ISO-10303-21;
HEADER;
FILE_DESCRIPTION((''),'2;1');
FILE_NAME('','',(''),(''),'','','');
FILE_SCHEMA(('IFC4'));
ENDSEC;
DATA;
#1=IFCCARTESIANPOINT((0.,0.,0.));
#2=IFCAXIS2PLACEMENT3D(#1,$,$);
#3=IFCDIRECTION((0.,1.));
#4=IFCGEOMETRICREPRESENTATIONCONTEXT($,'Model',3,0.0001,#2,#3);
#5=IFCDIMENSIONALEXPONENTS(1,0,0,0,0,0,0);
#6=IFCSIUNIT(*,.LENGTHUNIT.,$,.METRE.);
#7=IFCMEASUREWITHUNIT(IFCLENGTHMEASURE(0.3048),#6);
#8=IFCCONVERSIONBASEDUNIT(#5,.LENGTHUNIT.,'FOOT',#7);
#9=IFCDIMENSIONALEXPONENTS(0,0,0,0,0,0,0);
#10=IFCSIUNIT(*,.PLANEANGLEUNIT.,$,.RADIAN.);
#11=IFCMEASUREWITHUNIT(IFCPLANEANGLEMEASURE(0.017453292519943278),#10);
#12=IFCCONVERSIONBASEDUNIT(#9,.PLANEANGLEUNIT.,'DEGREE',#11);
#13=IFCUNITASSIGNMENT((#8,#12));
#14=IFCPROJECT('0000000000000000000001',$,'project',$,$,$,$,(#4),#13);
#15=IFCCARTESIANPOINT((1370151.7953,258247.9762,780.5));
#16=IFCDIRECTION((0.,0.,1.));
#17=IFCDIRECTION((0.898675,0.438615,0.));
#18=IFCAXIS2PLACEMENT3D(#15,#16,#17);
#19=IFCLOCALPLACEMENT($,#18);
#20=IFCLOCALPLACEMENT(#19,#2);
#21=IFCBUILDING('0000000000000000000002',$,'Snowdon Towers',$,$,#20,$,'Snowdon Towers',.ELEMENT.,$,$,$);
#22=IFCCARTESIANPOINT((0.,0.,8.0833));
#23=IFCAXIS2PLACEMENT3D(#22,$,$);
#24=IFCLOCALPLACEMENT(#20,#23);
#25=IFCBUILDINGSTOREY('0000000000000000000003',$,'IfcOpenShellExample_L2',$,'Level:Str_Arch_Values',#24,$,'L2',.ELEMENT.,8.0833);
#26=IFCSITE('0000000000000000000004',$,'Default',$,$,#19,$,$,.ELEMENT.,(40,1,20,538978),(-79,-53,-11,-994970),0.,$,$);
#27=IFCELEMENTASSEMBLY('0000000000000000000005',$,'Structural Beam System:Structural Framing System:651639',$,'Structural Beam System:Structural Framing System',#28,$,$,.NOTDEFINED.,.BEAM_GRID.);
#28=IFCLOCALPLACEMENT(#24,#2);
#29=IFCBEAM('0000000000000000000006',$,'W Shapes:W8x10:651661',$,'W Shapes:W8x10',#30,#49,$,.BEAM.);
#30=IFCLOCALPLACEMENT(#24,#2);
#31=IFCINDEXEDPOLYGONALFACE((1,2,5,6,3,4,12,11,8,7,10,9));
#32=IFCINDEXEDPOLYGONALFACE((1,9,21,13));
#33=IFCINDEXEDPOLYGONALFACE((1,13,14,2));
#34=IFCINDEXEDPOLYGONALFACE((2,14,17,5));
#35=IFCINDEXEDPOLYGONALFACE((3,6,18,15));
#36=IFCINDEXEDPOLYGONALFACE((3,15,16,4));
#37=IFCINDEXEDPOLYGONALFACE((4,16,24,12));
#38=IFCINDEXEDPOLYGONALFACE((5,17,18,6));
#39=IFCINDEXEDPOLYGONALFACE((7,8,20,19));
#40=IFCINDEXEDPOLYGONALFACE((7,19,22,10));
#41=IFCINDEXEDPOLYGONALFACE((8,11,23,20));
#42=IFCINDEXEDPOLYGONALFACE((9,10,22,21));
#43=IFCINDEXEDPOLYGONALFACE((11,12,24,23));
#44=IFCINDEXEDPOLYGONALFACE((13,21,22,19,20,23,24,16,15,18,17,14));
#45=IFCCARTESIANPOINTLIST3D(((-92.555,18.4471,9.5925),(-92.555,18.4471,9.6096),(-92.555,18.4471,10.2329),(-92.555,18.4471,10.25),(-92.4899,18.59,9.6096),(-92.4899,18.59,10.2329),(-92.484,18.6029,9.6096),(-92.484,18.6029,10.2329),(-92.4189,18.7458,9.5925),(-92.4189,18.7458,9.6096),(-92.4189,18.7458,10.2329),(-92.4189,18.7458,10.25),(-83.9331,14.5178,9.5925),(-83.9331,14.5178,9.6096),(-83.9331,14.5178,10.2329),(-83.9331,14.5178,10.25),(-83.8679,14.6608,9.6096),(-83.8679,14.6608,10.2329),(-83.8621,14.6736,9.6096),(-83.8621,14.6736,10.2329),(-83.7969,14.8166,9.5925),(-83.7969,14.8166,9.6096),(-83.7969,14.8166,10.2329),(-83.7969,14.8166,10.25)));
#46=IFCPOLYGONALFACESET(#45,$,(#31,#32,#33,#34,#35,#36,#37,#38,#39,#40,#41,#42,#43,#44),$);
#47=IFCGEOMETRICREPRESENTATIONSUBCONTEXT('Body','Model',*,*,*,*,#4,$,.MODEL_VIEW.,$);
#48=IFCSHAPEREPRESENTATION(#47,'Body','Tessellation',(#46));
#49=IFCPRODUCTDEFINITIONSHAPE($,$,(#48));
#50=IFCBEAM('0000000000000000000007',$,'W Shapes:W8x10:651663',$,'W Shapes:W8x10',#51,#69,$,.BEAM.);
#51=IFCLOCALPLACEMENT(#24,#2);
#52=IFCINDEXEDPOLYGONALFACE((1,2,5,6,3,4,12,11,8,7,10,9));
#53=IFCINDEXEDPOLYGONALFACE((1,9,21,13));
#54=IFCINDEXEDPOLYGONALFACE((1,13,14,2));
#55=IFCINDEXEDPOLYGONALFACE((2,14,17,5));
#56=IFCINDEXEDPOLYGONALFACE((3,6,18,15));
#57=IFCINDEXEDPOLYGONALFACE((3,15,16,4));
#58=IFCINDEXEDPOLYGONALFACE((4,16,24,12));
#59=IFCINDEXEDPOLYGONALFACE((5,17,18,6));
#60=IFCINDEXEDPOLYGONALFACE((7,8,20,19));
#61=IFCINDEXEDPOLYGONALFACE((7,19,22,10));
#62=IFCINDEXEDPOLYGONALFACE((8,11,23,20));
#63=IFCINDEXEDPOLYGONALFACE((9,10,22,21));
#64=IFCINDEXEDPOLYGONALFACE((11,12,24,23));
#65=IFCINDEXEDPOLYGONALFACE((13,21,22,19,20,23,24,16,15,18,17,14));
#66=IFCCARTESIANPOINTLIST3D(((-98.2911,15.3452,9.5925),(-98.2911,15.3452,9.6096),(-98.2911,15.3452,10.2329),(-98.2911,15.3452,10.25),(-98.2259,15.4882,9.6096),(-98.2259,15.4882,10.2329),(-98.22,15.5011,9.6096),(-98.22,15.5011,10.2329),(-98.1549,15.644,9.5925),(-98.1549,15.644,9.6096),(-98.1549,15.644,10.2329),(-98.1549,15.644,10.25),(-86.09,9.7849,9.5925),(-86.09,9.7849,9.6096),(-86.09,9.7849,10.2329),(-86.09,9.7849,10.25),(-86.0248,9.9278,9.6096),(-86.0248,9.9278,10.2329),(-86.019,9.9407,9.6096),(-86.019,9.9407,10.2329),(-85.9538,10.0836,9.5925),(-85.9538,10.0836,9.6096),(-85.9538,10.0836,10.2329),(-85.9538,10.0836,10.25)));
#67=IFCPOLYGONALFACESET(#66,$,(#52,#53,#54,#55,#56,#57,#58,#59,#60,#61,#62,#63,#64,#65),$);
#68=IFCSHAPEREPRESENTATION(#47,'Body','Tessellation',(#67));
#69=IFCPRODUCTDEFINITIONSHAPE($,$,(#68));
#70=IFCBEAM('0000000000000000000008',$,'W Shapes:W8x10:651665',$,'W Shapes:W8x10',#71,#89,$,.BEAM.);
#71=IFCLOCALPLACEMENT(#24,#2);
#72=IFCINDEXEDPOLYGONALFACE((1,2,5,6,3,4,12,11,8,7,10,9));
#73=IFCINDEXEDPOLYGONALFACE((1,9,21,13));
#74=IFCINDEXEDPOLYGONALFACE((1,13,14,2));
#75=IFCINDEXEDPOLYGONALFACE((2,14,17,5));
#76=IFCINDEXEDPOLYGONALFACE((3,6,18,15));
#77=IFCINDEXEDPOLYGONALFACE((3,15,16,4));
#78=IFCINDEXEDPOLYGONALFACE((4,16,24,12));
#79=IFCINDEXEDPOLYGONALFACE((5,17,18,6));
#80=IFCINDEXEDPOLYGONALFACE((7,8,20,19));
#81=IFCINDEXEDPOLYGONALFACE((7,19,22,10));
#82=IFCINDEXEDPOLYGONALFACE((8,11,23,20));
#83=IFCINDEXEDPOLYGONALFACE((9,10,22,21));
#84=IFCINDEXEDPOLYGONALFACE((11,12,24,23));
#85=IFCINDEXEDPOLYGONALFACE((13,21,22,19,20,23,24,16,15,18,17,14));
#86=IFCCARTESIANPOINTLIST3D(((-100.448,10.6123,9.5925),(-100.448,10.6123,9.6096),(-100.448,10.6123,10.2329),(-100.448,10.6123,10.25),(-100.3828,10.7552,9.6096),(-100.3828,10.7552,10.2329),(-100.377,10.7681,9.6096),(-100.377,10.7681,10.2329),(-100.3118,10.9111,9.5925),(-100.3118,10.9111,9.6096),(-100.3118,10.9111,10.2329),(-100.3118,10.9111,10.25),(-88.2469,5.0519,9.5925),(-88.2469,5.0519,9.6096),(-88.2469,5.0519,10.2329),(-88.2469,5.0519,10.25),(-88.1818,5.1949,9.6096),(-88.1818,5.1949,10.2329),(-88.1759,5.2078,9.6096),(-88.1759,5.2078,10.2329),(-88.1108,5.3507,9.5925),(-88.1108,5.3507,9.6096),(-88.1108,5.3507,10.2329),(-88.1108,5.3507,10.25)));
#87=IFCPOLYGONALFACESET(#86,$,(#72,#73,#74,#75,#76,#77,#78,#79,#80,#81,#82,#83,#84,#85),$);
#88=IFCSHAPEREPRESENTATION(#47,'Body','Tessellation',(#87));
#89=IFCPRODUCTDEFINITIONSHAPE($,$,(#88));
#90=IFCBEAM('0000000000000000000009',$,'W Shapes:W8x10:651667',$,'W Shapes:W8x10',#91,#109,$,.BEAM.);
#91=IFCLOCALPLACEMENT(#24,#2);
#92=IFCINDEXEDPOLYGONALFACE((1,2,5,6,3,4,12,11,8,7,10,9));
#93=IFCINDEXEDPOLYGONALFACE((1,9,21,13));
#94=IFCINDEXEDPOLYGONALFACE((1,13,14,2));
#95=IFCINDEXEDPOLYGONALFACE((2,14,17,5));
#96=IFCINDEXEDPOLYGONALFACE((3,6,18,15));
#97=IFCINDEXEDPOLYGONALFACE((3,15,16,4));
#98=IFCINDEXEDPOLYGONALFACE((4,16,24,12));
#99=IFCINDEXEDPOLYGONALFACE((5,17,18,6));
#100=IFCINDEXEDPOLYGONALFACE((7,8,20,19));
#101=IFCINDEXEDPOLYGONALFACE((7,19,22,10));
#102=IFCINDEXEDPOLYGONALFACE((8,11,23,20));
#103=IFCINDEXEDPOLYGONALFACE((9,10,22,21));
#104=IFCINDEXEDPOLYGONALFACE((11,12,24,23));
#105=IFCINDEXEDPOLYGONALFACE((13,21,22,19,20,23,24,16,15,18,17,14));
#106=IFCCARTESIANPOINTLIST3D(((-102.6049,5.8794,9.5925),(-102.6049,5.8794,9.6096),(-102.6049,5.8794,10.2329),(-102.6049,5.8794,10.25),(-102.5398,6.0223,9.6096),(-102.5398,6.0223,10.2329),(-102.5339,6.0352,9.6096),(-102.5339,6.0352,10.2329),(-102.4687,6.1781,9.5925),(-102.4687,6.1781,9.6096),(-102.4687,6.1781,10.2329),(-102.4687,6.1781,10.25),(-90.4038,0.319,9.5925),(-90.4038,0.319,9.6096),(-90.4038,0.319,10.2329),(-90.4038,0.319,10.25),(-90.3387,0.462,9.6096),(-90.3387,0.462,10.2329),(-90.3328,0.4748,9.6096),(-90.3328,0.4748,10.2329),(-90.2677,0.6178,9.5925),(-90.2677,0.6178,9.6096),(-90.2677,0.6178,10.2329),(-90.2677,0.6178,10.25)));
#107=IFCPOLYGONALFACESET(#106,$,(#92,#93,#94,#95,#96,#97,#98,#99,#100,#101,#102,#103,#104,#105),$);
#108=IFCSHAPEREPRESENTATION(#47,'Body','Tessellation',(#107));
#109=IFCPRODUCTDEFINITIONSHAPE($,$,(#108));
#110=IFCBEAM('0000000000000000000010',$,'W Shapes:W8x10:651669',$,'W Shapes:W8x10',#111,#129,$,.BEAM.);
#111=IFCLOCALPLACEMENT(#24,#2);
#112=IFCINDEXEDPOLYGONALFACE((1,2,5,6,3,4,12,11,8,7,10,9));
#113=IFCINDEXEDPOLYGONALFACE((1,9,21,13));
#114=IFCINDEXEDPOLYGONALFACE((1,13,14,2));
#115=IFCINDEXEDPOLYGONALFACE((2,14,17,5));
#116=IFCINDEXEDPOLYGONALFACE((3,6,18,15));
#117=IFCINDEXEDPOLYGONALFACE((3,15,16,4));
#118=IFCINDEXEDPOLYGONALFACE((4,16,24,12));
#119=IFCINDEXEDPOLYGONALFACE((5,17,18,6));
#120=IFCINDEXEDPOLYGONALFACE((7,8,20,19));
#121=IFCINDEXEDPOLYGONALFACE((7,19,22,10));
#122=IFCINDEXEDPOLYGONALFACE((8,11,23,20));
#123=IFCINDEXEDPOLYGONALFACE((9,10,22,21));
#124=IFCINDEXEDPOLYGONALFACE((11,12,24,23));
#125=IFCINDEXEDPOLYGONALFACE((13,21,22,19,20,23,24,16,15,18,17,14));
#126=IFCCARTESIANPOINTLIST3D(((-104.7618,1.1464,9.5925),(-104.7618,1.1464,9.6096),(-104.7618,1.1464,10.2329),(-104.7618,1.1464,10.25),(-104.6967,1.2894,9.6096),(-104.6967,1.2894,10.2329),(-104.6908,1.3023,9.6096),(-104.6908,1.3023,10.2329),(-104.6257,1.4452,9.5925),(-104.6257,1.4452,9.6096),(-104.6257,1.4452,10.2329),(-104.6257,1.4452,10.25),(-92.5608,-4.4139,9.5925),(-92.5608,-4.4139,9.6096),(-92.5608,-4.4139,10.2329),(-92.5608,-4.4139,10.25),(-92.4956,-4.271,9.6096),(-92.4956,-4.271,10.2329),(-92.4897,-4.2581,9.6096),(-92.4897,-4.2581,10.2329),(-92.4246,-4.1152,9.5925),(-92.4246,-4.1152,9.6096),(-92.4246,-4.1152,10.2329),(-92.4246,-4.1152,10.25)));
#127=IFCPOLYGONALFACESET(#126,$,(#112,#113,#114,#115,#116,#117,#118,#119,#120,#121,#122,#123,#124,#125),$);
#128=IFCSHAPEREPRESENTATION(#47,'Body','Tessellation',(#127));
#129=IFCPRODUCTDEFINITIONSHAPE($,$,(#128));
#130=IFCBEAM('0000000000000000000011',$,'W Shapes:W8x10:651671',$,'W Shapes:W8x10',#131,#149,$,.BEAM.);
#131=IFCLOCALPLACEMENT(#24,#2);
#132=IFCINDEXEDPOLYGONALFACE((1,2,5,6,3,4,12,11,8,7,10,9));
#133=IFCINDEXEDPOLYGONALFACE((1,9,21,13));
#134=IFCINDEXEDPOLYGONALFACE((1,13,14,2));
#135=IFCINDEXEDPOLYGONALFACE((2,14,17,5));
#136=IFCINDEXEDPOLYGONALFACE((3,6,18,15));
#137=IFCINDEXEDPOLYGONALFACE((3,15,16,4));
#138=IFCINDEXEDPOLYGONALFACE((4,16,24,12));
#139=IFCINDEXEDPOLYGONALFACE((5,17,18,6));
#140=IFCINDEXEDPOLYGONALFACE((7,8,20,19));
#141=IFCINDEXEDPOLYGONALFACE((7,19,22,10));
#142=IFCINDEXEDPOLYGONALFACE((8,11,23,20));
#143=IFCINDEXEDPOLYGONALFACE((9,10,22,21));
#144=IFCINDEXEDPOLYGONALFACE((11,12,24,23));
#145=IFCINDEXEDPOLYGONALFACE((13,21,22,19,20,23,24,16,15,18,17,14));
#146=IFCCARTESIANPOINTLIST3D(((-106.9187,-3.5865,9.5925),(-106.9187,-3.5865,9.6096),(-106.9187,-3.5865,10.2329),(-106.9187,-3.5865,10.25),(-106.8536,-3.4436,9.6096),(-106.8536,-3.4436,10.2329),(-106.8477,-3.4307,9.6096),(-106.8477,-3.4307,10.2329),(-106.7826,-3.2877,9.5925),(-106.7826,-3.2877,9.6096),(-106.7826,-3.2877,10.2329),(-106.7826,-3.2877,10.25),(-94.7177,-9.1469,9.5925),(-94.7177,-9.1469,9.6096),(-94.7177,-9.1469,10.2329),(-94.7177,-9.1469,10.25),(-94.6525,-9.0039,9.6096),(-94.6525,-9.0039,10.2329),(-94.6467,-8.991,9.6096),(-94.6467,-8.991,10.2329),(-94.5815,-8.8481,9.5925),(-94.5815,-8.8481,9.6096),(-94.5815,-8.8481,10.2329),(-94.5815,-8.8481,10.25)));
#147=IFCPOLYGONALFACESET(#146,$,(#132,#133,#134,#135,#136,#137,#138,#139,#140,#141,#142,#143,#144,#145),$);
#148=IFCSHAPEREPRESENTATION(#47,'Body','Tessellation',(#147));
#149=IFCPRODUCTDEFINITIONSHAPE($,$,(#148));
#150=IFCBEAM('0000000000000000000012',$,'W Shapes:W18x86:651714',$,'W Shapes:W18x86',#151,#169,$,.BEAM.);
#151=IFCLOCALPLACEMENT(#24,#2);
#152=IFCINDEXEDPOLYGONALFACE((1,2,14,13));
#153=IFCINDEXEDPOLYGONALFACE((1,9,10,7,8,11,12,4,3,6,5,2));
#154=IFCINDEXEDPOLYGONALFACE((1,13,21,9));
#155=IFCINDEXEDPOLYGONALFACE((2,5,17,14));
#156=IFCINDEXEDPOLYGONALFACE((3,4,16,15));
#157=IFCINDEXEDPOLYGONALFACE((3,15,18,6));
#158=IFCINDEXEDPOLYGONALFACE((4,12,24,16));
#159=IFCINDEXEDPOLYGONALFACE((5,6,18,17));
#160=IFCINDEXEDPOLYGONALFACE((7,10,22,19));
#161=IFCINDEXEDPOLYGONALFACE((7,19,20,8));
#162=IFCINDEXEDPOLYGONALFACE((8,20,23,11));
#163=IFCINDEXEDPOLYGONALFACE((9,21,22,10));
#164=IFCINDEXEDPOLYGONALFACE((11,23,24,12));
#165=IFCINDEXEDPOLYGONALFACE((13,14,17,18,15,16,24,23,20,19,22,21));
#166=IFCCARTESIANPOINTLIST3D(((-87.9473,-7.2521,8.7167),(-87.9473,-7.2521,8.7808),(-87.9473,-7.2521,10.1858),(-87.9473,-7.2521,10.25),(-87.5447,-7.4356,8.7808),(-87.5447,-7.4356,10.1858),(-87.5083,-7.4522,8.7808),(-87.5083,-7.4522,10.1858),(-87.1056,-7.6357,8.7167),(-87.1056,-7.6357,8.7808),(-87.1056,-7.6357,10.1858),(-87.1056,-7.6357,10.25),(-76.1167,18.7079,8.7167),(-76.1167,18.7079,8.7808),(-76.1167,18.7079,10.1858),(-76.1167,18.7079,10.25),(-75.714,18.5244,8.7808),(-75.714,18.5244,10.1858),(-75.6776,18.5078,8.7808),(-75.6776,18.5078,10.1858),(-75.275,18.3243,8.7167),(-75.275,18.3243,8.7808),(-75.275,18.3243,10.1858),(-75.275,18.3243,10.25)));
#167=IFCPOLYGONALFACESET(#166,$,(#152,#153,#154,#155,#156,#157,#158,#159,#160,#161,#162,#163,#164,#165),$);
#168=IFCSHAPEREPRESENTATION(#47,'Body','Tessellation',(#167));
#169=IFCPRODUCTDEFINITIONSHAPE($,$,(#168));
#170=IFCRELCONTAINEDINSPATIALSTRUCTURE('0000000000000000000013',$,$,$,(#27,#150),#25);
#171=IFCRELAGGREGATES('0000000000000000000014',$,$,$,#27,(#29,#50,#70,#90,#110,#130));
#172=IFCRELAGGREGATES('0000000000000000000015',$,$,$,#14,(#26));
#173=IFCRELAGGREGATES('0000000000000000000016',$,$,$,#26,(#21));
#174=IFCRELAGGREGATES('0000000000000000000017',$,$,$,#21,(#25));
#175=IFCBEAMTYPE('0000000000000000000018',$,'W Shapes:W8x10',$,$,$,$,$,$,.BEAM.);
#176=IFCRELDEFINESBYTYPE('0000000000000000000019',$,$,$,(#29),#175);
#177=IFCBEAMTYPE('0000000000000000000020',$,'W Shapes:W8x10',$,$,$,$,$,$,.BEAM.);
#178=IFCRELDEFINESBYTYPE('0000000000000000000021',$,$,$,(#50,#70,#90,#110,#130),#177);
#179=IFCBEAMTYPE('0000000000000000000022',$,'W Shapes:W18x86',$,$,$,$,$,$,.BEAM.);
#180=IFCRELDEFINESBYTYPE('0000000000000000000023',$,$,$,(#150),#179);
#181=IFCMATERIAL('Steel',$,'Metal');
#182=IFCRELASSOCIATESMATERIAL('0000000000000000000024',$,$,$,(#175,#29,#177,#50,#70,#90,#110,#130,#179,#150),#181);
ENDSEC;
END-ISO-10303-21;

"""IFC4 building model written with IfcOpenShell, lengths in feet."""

from ifc_helpers import new_model, entity, si_unit, converted_unit, direction, frame, origin, place, context, subcontext, project, spatial, indexed_curve, outline, extrude, source, transform, mapped, material, type_object, type_shapes, element, aggregate, save


model = new_model("IFC4")

# Units and contexts
model_context = context("Model", 3, precision=0.0001, world=origin(), true_north=direction((0.0, 1.0)))
body_context = subcontext(model_context, "Body", "Model", "MODEL_VIEW")
ifc_project = project(units=[converted_unit("LENGTHUNIT", "FOOT", entity("IfcLengthMeasure", 0.3048), si_unit("LENGTHUNIT", "METRE"), dimensions=[1, 0, 0, 0, 0, 0, 0]), converted_unit("PLANEANGLEUNIT", "DEGREE", entity("IfcPlaneAngleMeasure", 0.017453292519943278), si_unit("PLANEANGLEUNIT", "RADIAN"), dimensions=[0, 0, 0, 0, 0, 0, 0])], contexts=[model_context])

# Site, building, storey
site_placement = place(None, frame((1370151.7953, 258247.9762, 780.5), z_axis=(0.0, 0.0, 1.0), x_axis=(0.898675, 0.438615, 0.0)))
site = spatial("IfcSite", under=ifc_project, at=site_placement, Name="Default", CompositionType="ELEMENT", RefLatitude=(40, 1, 20, 538978), RefLongitude=(-79, -53, -11, -994970), RefElevation=0.0)
building_placement = place(site_placement, origin())
building = spatial("IfcBuilding", under=site, at=building_placement, Name="Snowdon Towers", LongName="Snowdon Towers", CompositionType="ELEMENT")
storey_placement = place(building_placement, frame((0.0, 0.0, 8.0833)))
storey = spatial("IfcBuildingStorey", under=building, at=storey_placement, Name="IfcOpenShellExample_L2", ObjectType="Level:Str_Arch_Values", LongName="L2", CompositionType="ELEMENT", Elevation=8.0833)

# Shared definitions
ifc_material = material(Name="Steel", Category="Metal")

# Element assembly, beams
assembly_1_placement = place(storey_placement, origin())
assembly_1 = element("IfcElementAssembly", 1, at=assembly_1_placement, inside=storey, Name="Structural Beam System:Structural Framing System:651639", ObjectType="Structural Beam System:Structural Framing System", AssemblyPlace="NOTDEFINED", PredefinedType="BEAM_GRID")
beam_type_1 = type_object("IfcBeamType", Name="W Shapes:W8x10", PredefinedType="BEAM", material=ifc_material)
shared_shape_1 = source(origin(), body_context, "Body", "SweptSolid", [
    extrude(outline(indexed_curve([(-0.1642, -0.3117), (-0.1642, -0.3288), (0.1642, -0.3288), (0.1642, -0.3117), (0.0071, -0.3117), (0.0071, 0.3117), (0.1642, 0.3117), (0.1642, 0.3287), (-0.1642, 0.3287), (-0.1642, 0.3117), (-0.0071, 0.3117), (-0.0071, -0.3117), (-0.1642, -0.3117)], self_intersect=False)), frame((-4.231, 0.0, 0.0), z_axis=(-1.0, 0.0, 0.0), x_axis=(0.0, -1.0, 0.0)), (0.0, 0.0, -1.0), 9.4751),
])
type_shapes(beam_type_1, [shared_shape_1])
beam_1_placement = place(assembly_1_placement, frame((-88.6369, 16.8419, 9.9213), z_axis=(0.0, 0.0, 1.0), x_axis=(0.909961, -0.414693, 0.0)))
beam_1 = element("IfcBeam", 2, at=beam_1_placement, type_object=beam_type_1, material=ifc_material, Name="W Shapes:W8x10:651661", ObjectType="W Shapes:W8x10", PredefinedType="BEAM", context=body_context, shape_type="MappedRepresentation", body=[
    mapped(shared_shape_1, transform((0.0, 0.0, 0.0), scale=1.0)),
])
beam_type_2 = type_object("IfcBeamType", Name="W Shapes:W8x10", PredefinedType="BEAM", material=ifc_material)
shared_shape_2 = source(origin(), body_context, "Body", "SweptSolid", [
    extrude(outline(indexed_curve([(-0.1642, -0.3117), (-0.1642, -0.3288), (0.1642, -0.3288), (0.1642, -0.3117), (0.0071, -0.3117), (0.0071, 0.3117), (0.1642, 0.3117), (0.1642, 0.3287), (-0.1642, 0.3287), (-0.1642, 0.3117), (-0.0071, 0.3117), (-0.0071, -0.3117), (-0.1642, -0.3117)], self_intersect=False)), frame((-6.7042, 0.0, 0.0), z_axis=(-1.0, 0.0, 0.0), x_axis=(0.0, -1.0, 0.0)), (0.0, 0.0, -1.0), 13.4083),
])
type_shapes(beam_type_2, [shared_shape_2])
beam_2_placement = place(assembly_1_placement, frame((-92.1224, 12.7144, 9.9213), z_axis=(0.0, 0.0, 1.0), x_axis=(0.909961, -0.414693, 0.0)))
beam_2 = element("IfcBeam", 3, at=beam_2_placement, type_object=beam_type_2, material=ifc_material, Name="W Shapes:W8x10:651663", ObjectType="W Shapes:W8x10", PredefinedType="BEAM", context=body_context, shape_type="MappedRepresentation", body=[
    mapped(shared_shape_2, transform((0.0, 0.0, 0.0), scale=1.0)),
])
beam_3_placement = place(assembly_1_placement, frame((-94.2794, 7.9815, 9.9213), z_axis=(0.0, 0.0, 1.0), x_axis=(0.909961, -0.414693, 0.0)))
beam_3 = element("IfcBeam", 4, at=beam_3_placement, type_object=beam_type_2, material=ifc_material, Name="W Shapes:W8x10:651665", ObjectType="W Shapes:W8x10", PredefinedType="BEAM", context=body_context, shape_type="MappedRepresentation", body=[
    mapped(shared_shape_2, transform((0.0, 0.0, 0.0), scale=1.0)),
])
beam_4_placement = place(assembly_1_placement, frame((-96.4363, 3.2486, 9.9213), z_axis=(0.0, 0.0, 1.0), x_axis=(0.909961, -0.414693, 0.0)))
beam_4 = element("IfcBeam", 5, at=beam_4_placement, type_object=beam_type_2, material=ifc_material, Name="W Shapes:W8x10:651667", ObjectType="W Shapes:W8x10", PredefinedType="BEAM", context=body_context, shape_type="MappedRepresentation", body=[
    mapped(shared_shape_2, transform((0.0, 0.0, 0.0), scale=1.0)),
])
beam_5_placement = place(assembly_1_placement, frame((-98.5932, -1.4844, 9.9213), z_axis=(0.0, 0.0, 1.0), x_axis=(0.909961, -0.414693, 0.0)))
beam_5 = element("IfcBeam", 6, at=beam_5_placement, type_object=beam_type_2, material=ifc_material, Name="W Shapes:W8x10:651669", ObjectType="W Shapes:W8x10", PredefinedType="BEAM", context=body_context, shape_type="MappedRepresentation", body=[
    mapped(shared_shape_2, transform((0.0, 0.0, 0.0), scale=1.0)),
])
beam_6_placement = place(assembly_1_placement, frame((-100.7501, -6.2173, 9.9213), z_axis=(0.0, 0.0, 1.0), x_axis=(0.909961, -0.414693, 0.0)))
beam_6 = element("IfcBeam", 7, at=beam_6_placement, type_object=beam_type_2, material=ifc_material, Name="W Shapes:W8x10:651671", ObjectType="W Shapes:W8x10", PredefinedType="BEAM", context=body_context, shape_type="MappedRepresentation", body=[
    mapped(shared_shape_2, transform((0.0, 0.0, 0.0), scale=1.0)),
])
aggregate(assembly_1, [beam_1, beam_2, beam_3, beam_4, beam_5, beam_6])

# Beam
beam_type_3 = type_object("IfcBeamType", Name="W Shapes:W18x86", PredefinedType="BEAM", material=ifc_material)
shared_shape_3 = source(origin(), body_context, "Body", "SweptSolid", [
    extrude(outline(indexed_curve([(-0.4625, -0.7025), (-0.4625, -0.7667), (0.4625, -0.7667), (0.4625, -0.7025), (0.02, -0.7025), (0.02, 0.7025), (0.4625, 0.7025), (0.4625, 0.7667), (-0.4625, 0.7667), (-0.4625, 0.7025), (-0.02, 0.7025), (-0.02, -0.7025), (-0.4625, -0.7025)], self_intersect=False)), frame((-14.3926, 0.0, 0.0), z_axis=(-1.0, 0.0, 0.0), x_axis=(0.0, -1.0, 0.0)), (0.0, 0.0, -1.0), 28.5287),
])
type_shapes(beam_type_3, [shared_shape_3])
beam_7_placement = place(storey_placement, frame((-81.558, 5.6528, 9.4833), z_axis=(0.0, 0.0, 1.0), x_axis=(0.414693, 0.909961, 0.0)))
element("IfcBeam", 8, at=beam_7_placement, inside=storey, type_object=beam_type_3, material=ifc_material, Name="W Shapes:W18x86:651714", ObjectType="W Shapes:W18x86", PredefinedType="BEAM", context=body_context, shape_type="MappedRepresentation", body=[
    mapped(shared_shape_3, transform((0.0, 0.0, 0.0), scale=1.0)),
])

save(model, "model.ifc")
